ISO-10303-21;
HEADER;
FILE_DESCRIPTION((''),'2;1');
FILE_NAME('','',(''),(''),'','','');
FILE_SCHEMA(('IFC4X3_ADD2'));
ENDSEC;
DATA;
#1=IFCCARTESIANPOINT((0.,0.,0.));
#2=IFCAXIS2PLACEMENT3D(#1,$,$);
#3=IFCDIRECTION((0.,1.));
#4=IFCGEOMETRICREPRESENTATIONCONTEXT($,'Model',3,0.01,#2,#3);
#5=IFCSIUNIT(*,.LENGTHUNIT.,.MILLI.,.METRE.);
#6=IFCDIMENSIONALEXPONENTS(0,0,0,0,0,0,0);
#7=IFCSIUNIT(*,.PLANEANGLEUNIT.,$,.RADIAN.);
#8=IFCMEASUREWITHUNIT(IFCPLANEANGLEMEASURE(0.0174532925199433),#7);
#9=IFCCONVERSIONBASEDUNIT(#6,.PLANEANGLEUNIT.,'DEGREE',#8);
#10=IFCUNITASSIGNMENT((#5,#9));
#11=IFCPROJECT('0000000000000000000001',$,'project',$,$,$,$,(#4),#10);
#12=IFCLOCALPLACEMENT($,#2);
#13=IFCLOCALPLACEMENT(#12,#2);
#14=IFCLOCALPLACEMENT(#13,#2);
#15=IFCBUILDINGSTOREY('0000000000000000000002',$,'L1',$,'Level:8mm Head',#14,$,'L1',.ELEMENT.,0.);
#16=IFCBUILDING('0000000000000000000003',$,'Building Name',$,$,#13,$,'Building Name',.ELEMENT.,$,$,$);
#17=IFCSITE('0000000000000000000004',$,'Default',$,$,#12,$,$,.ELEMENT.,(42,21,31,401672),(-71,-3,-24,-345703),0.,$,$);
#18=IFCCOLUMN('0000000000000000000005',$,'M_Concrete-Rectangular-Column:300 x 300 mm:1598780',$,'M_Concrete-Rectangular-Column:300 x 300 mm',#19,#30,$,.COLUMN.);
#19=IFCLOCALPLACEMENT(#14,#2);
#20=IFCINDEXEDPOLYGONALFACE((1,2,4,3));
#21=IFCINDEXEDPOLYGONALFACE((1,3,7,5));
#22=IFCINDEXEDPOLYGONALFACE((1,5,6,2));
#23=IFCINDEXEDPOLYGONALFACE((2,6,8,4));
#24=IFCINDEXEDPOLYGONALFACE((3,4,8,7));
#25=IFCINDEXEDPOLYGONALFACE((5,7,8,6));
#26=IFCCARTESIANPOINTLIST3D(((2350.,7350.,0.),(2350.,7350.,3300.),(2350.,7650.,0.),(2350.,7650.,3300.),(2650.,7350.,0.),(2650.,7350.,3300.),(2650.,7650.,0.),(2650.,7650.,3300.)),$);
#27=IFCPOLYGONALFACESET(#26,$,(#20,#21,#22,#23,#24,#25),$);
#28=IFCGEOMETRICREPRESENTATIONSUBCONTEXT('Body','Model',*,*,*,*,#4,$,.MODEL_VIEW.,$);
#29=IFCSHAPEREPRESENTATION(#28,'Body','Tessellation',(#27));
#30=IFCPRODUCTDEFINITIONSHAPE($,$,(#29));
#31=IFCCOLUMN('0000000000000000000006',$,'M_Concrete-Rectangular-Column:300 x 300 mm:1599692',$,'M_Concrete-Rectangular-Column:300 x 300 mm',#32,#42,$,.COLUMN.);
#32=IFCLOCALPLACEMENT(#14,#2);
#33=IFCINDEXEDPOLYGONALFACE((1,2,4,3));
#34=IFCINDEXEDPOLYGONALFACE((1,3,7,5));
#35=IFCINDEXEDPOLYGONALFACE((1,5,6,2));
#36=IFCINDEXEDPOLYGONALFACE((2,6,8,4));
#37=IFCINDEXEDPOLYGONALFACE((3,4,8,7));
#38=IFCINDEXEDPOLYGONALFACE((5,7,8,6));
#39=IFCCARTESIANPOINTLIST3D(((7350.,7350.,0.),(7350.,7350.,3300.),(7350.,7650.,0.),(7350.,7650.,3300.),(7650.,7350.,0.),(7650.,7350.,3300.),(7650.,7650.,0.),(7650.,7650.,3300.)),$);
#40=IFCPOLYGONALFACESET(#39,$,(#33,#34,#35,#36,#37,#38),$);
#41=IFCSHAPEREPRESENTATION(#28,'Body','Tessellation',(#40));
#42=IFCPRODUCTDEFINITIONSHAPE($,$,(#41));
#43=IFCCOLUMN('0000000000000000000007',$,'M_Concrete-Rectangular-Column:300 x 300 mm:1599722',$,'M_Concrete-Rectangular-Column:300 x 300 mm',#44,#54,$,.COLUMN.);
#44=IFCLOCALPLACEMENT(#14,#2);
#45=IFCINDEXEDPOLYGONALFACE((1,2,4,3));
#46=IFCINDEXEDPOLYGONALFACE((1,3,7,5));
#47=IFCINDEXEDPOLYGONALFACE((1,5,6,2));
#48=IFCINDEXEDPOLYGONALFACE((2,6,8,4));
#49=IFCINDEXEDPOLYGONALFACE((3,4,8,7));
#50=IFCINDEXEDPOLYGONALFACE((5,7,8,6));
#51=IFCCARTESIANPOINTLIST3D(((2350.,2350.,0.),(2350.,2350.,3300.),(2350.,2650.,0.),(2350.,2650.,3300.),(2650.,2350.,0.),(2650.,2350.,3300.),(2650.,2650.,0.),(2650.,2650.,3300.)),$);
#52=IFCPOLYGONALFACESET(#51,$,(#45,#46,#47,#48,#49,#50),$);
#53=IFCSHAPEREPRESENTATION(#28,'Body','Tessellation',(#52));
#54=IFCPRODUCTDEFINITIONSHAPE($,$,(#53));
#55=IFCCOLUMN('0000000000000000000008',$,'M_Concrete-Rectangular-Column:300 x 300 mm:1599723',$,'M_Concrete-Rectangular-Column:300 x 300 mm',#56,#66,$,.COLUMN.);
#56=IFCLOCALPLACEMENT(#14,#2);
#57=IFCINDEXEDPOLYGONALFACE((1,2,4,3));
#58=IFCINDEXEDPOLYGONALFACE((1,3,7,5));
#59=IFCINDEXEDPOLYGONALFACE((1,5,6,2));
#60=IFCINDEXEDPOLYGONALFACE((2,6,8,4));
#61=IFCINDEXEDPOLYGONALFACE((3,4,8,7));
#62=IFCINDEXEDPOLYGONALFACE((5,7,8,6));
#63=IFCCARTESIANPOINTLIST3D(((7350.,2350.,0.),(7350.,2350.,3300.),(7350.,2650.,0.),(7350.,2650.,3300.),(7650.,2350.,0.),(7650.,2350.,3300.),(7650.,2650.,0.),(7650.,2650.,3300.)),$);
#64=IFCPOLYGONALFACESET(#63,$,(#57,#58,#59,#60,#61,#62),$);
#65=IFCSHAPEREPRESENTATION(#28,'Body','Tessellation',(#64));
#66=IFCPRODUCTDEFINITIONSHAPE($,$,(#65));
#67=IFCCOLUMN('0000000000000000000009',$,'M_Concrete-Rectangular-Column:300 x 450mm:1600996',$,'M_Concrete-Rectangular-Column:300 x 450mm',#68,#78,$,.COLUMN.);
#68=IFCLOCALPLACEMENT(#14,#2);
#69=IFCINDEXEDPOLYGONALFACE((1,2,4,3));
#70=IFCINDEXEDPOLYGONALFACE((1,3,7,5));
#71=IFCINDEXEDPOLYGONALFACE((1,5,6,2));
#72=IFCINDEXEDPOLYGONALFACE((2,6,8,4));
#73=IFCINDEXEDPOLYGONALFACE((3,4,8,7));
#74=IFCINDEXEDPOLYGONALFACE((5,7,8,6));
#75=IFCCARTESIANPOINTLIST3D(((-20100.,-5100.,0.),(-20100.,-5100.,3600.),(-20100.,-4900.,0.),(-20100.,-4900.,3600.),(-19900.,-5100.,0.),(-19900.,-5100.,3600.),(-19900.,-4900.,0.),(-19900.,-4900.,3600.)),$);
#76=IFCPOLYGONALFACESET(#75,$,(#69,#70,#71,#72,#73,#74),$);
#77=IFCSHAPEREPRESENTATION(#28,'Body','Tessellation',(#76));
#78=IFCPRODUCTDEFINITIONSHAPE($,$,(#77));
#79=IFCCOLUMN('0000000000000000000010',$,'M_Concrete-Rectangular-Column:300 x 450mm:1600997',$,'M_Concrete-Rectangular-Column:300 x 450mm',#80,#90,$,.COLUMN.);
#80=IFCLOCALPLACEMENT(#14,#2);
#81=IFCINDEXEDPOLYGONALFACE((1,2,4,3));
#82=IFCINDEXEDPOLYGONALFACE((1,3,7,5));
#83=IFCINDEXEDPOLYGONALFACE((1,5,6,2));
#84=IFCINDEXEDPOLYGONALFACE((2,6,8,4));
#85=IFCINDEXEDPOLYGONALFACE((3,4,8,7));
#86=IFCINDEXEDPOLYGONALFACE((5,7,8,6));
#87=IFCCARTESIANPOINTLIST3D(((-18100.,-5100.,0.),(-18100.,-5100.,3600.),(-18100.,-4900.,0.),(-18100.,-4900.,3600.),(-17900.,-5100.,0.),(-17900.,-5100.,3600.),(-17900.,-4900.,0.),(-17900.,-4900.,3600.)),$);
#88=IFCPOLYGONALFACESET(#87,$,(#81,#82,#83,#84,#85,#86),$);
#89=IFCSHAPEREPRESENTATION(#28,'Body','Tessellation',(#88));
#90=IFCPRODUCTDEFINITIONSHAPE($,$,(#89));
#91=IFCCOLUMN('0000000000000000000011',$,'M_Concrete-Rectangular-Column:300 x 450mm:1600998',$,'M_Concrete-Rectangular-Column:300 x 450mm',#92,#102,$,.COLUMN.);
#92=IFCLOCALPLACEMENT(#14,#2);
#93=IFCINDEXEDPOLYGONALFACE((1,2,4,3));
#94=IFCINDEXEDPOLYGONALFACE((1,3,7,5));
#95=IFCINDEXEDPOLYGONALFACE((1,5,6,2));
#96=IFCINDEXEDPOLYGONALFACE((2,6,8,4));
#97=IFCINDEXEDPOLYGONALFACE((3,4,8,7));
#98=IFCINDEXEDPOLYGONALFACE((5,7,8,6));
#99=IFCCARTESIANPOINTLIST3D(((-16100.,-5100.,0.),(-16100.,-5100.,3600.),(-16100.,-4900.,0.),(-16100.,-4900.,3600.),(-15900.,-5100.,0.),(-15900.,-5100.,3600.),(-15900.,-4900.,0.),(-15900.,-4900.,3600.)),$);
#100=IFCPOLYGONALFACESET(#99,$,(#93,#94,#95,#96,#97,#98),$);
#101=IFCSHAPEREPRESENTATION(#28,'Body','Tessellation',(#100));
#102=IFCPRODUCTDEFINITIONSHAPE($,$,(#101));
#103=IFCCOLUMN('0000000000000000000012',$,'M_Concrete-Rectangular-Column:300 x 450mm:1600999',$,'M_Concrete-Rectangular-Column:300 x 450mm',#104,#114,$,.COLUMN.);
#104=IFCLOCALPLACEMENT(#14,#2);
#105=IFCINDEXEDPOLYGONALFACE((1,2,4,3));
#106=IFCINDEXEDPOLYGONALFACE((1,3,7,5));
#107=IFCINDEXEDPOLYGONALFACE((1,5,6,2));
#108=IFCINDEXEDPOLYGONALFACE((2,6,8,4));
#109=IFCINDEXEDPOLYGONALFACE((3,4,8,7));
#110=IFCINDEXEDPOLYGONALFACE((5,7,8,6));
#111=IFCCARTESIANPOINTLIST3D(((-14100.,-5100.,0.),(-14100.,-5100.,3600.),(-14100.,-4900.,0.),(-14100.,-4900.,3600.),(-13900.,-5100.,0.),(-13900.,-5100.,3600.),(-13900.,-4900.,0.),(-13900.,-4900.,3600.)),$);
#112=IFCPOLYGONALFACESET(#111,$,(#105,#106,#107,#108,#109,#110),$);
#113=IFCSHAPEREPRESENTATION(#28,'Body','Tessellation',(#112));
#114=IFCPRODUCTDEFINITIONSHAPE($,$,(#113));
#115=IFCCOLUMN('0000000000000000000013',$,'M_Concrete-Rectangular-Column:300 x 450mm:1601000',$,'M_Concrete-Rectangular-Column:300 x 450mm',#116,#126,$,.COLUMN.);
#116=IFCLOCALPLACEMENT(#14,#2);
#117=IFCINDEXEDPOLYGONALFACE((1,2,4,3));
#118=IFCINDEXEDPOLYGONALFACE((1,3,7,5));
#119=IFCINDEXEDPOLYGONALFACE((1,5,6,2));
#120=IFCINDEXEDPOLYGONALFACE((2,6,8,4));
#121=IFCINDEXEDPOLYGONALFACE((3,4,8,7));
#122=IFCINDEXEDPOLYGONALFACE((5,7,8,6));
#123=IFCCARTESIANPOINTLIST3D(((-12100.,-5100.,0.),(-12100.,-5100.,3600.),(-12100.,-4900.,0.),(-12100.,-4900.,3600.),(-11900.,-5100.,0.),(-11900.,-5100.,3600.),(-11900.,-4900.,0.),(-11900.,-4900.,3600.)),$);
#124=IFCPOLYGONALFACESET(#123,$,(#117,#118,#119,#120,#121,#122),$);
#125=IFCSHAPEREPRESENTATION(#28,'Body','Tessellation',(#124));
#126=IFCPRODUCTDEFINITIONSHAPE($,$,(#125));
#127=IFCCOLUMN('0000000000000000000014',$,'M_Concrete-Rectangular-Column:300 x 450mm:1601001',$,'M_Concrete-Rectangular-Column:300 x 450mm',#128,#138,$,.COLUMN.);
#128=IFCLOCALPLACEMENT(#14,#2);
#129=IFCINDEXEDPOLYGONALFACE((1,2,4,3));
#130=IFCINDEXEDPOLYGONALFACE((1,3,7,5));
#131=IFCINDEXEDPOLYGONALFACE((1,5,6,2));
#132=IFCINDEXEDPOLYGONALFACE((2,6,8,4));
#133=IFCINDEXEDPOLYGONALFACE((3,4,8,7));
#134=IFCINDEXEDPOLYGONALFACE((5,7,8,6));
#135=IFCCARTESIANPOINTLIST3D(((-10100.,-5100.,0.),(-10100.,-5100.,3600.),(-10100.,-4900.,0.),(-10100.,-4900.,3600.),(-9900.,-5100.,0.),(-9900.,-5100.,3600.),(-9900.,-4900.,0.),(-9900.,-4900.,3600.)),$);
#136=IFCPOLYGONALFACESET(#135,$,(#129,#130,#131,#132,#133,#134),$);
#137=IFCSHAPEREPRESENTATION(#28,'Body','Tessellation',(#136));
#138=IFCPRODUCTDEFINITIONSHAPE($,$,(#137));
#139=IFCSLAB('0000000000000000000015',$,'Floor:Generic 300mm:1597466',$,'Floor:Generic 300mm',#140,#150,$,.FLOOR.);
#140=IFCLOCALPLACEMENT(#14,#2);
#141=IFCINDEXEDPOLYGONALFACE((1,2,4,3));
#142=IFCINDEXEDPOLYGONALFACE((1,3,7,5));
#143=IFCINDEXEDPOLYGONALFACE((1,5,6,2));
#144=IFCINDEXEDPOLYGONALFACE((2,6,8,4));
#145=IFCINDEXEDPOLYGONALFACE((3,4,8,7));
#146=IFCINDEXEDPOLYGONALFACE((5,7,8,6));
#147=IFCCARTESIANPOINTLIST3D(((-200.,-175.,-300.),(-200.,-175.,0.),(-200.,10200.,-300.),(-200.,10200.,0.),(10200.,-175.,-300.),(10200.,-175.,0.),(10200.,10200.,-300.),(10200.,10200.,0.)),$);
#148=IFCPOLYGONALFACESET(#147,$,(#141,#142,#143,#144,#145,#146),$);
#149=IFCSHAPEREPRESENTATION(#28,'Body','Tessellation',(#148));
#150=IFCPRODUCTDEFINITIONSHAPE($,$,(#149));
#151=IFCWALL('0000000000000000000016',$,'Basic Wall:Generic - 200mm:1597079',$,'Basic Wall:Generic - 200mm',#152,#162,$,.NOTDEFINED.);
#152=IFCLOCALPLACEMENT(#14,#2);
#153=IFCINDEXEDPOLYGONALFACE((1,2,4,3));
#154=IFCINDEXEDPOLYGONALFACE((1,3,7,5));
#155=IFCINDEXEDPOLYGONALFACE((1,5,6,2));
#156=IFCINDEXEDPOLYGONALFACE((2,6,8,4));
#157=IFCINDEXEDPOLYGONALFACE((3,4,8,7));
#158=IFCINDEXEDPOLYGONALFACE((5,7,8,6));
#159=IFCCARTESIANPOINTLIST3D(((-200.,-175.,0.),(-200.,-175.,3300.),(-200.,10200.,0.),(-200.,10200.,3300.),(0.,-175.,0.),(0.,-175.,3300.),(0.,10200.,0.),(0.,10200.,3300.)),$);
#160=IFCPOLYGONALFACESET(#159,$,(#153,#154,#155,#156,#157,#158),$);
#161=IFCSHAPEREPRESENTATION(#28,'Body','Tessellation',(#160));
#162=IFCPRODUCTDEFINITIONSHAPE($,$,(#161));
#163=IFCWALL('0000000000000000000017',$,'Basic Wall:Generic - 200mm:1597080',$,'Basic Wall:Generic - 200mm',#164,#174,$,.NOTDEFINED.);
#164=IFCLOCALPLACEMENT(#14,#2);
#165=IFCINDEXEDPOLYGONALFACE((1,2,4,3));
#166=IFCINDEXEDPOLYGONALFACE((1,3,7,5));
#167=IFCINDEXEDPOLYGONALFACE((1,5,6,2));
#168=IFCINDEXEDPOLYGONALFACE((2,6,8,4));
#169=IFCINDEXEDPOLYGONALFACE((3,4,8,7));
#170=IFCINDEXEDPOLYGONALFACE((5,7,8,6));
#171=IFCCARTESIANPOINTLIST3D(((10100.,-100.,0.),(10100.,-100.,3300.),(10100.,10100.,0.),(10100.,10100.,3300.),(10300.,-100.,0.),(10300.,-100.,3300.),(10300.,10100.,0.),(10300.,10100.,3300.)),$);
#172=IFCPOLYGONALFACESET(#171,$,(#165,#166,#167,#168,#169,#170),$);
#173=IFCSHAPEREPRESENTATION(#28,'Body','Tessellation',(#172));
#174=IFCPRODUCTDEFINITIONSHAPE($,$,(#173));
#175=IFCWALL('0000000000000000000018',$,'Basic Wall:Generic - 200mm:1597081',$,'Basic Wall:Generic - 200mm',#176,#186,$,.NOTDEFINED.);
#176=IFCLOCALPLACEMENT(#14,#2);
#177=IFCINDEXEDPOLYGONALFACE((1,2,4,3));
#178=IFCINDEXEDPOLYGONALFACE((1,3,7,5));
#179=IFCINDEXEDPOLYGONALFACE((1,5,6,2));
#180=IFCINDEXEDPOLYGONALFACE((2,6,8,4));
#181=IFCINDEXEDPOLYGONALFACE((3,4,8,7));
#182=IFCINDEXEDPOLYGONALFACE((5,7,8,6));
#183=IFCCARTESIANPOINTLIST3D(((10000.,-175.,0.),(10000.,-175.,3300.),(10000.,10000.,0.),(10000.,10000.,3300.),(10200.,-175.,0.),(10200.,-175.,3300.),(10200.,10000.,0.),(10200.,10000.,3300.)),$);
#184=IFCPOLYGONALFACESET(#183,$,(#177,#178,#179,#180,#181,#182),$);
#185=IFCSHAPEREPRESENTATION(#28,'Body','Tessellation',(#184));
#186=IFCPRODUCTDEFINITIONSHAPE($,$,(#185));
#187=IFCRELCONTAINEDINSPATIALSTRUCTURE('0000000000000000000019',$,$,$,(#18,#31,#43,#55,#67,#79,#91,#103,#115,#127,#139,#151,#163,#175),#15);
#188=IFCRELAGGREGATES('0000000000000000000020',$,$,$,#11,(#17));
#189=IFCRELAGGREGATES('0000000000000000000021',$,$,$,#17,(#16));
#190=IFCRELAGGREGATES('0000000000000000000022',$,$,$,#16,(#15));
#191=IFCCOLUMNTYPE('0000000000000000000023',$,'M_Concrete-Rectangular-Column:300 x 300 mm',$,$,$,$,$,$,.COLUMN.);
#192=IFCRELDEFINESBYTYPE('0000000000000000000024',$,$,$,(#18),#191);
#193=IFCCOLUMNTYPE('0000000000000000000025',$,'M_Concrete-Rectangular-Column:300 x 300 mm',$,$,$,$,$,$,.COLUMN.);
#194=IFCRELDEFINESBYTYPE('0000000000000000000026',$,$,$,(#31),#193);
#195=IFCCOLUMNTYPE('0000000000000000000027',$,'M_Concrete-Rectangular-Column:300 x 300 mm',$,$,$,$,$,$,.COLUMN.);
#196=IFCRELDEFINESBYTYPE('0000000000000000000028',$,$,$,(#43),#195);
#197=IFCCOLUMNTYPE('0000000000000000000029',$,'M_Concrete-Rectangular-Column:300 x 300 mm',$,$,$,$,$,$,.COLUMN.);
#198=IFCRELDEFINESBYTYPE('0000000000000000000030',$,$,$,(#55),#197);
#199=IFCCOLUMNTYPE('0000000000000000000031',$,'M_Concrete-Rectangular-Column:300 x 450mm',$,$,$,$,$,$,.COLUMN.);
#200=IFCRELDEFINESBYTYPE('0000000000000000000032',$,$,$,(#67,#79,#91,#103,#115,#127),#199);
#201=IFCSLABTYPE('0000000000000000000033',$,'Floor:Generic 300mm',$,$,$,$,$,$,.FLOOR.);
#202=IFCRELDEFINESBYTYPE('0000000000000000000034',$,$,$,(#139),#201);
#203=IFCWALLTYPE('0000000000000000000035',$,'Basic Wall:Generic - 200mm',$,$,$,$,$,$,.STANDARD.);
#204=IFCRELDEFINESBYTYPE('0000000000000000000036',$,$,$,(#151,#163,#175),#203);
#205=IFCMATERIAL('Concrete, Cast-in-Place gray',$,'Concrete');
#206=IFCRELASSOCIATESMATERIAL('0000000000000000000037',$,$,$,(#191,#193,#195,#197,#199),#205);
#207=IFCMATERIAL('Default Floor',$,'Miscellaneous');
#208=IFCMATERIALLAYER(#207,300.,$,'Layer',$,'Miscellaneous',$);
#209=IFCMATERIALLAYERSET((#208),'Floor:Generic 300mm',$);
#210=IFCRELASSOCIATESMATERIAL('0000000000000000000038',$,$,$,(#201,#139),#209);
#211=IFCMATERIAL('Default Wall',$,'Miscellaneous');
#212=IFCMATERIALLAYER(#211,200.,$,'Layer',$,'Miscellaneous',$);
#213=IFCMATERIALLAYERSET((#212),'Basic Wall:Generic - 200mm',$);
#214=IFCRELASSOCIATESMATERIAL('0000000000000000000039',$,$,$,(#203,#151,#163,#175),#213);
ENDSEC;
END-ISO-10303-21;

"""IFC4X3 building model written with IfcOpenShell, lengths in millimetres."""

from ifc_helpers import new_model, entity, si_unit, converted_unit, direction, frame, frame_2d, origin, origin_2d_with_axis, place, context, subcontext, project, spatial, rectangle, extrude, source, transform, mapped, material, layer, layer_set, layer_usage, material_profile, profile_set, type_object, type_shapes, element, save


model = new_model("IFC4X3")

# Units and contexts
model_context = context("Model", 3, precision=0.01, world=origin(), true_north=direction((0.0, 1.0)))
body_context = subcontext(model_context, "Body", "Model", "MODEL_VIEW")
ifc_project = project(units=[si_unit("LENGTHUNIT", "METRE", prefix="MILLI"), converted_unit("PLANEANGLEUNIT", "DEGREE", entity("IfcPlaneAngleMeasure", 0.0174532925199433), si_unit("PLANEANGLEUNIT", "RADIAN"), dimensions=[0, 0, 0, 0, 0, 0, 0])], contexts=[model_context])

# Site, building, storey
site_placement = place(None, origin())
site = spatial("IfcSite", under=ifc_project, at=site_placement, Name="Default", CompositionType="ELEMENT", RefLatitude=(42, 21, 31, 401672), RefLongitude=(-71, -3, -24, -345703), RefElevation=0.0)
building_placement = place(site_placement, origin())
building = spatial("IfcBuilding", under=site, at=building_placement, Name="Building Name", LongName="Building Name", CompositionType="ELEMENT")
storey_placement = place(building_placement, origin())
storey = spatial("IfcBuildingStorey", under=building, at=storey_placement, Name="L1", ObjectType="Level:8mm Head", LongName="L1", CompositionType="ELEMENT", Elevation=0.0)

# Columns
ifc_material_1 = material(Name="Concrete, Cast-in-Place gray", Category="Concrete")
ifc_material_profile_1 = material_profile(ifc_material_1, rectangle(XDim=300.0, YDim=300.0, at=origin_2d_with_axis()), Name="300 x 300 mm")
ifc_profile_set_1 = profile_set([ifc_material_profile_1], Name="300 x 300 mm")
column_type_1 = type_object("IfcColumnType", Name="M_Concrete-Rectangular-Column:300 x 300 mm", PredefinedType="COLUMN", material=ifc_profile_set_1)
shared_shape_1 = source(origin(), body_context, "Body", "SweptSolid", [
    extrude(rectangle(XDim=300.0, YDim=300.0, at=origin_2d_with_axis()), frame((2500.0, 7500.0, 0.0)), (0.0, 0.0, 1.0), 3300.0),
])
type_shapes(column_type_1, [shared_shape_1])
column_1_placement = place(storey_placement, origin())
element("IfcColumn", 1, at=column_1_placement, inside=storey, type_object=column_type_1, Name="M_Concrete-Rectangular-Column:300 x 300 mm:1598780", ObjectType="M_Concrete-Rectangular-Column:300 x 300 mm", PredefinedType="COLUMN", context=body_context, shape_type="MappedRepresentation", body=[
    mapped(shared_shape_1, transform((0.0, 0.0, 0.0), scale=1.0)),
])
column_type_2 = type_object("IfcColumnType", Name="M_Concrete-Rectangular-Column:300 x 300 mm", PredefinedType="COLUMN", material=ifc_profile_set_1)
shared_shape_2 = source(origin(), body_context, "Body", "SweptSolid", [
    extrude(rectangle(XDim=300.0, YDim=300.0, at=origin_2d_with_axis()), frame((7500.0, 7500.0, 0.0)), (0.0, 0.0, 1.0), 3300.0),
])
type_shapes(column_type_2, [shared_shape_2])
column_2_placement = place(storey_placement, origin())
element("IfcColumn", 2, at=column_2_placement, inside=storey, type_object=column_type_2, Name="M_Concrete-Rectangular-Column:300 x 300 mm:1599692", ObjectType="M_Concrete-Rectangular-Column:300 x 300 mm", PredefinedType="COLUMN", context=body_context, shape_type="MappedRepresentation", body=[
    mapped(shared_shape_2, transform((0.0, 0.0, 0.0), scale=1.0)),
])
column_type_3 = type_object("IfcColumnType", Name="M_Concrete-Rectangular-Column:300 x 300 mm", PredefinedType="COLUMN", material=ifc_profile_set_1)
shared_shape_3 = source(origin(), body_context, "Body", "SweptSolid", [
    extrude(rectangle(XDim=300.0, YDim=300.0, at=origin_2d_with_axis()), frame((2500.0, 2500.0, 0.0)), (0.0, 0.0, 1.0), 3300.0),
])
type_shapes(column_type_3, [shared_shape_3])
column_3_placement = place(storey_placement, origin())
element("IfcColumn", 3, at=column_3_placement, inside=storey, type_object=column_type_3, Name="M_Concrete-Rectangular-Column:300 x 300 mm:1599722", ObjectType="M_Concrete-Rectangular-Column:300 x 300 mm", PredefinedType="COLUMN", context=body_context, shape_type="MappedRepresentation", body=[
    mapped(shared_shape_3, transform((0.0, 0.0, 0.0), scale=1.0)),
])
column_type_4 = type_object("IfcColumnType", Name="M_Concrete-Rectangular-Column:300 x 300 mm", PredefinedType="COLUMN", material=ifc_profile_set_1)
shared_shape_4 = source(origin(), body_context, "Body", "SweptSolid", [
    extrude(rectangle(XDim=300.0, YDim=300.0, at=origin_2d_with_axis()), frame((7500.0, 2500.0, 0.0)), (0.0, 0.0, 1.0), 3300.0),
])
type_shapes(column_type_4, [shared_shape_4])
column_4_placement = place(storey_placement, origin())
element("IfcColumn", 4, at=column_4_placement, inside=storey, type_object=column_type_4, Name="M_Concrete-Rectangular-Column:300 x 300 mm:1599723", ObjectType="M_Concrete-Rectangular-Column:300 x 300 mm", PredefinedType="COLUMN", context=body_context, shape_type="MappedRepresentation", body=[
    mapped(shared_shape_4, transform((0.0, 0.0, 0.0), scale=1.0)),
])
ifc_material_profile_2 = material_profile(ifc_material_1, rectangle(XDim=200.0, YDim=200.0, at=origin_2d_with_axis()), Name="300 x 450mm")
ifc_profile_set_2 = profile_set([ifc_material_profile_2], Name="300 x 450mm")
column_type_5 = type_object("IfcColumnType", Name="M_Concrete-Rectangular-Column:300 x 450mm", PredefinedType="COLUMN", material=ifc_profile_set_2)
shared_shape_5 = source(origin(), body_context, "Body", "SweptSolid", [
    extrude(rectangle(XDim=200.0, YDim=200.0, at=origin_2d_with_axis()), frame((0.0, 0.0, 0.0), z_axis=(0.0, 0.0, 1.0), x_axis=(0.0, -1.0, 0.0)), (0.0, 0.0, 1.0), 3600.0),
])
type_shapes(column_type_5, [shared_shape_5])
for number, where, z_axis, x_axis, name in (
    (5, (-20000.0, -5000.0, 0.0), (0.0, 0.0, 1.0), (0.0, -1.0, 0.0), "M_Concrete-Rectangular-Column:300 x 450mm:1600996"),
    (6, (-18000.0, -5000.0, 0.0), (0.0, 0.0, 1.0), (0.0, -1.0, 0.0), "M_Concrete-Rectangular-Column:300 x 450mm:1600997"),
    (7, (-16000.0, -5000.0, 0.0), (0.0, 0.0, 1.0), (0.0, -1.0, 0.0), "M_Concrete-Rectangular-Column:300 x 450mm:1600998"),
    (8, (-14000.0, -5000.0, 0.0), (0.0, 0.0, 1.0), (0.0, -1.0, 0.0), "M_Concrete-Rectangular-Column:300 x 450mm:1600999"),
    (9, (-12000.0, -5000.0, 0.0), (0.0, 0.0, 1.0), (0.0, -1.0, 0.0), "M_Concrete-Rectangular-Column:300 x 450mm:1601000"),
    (10, (-10000.0, -5000.0, 0.0), (0.0, 0.0, 1.0), (0.0, -1.0, 0.0), "M_Concrete-Rectangular-Column:300 x 450mm:1601001"),
):
    element("IfcColumn", number, at=place(storey_placement, frame(where, z_axis=z_axis, x_axis=x_axis)), inside=storey, type_object=column_type_5, Name=name, ObjectType="M_Concrete-Rectangular-Column:300 x 450mm", PredefinedType="COLUMN", context=body_context, shape_type="MappedRepresentation", body=[
        mapped(shared_shape_5, transform((0.0, 0.0, 0.0), scale=1.0)),
    ])

# Slab
ifc_material_2 = material(Name="Default Floor", Category="Miscellaneous")
ifc_layer_1 = layer(ifc_material_2, 300.0, Name="Layer", Category="Miscellaneous")
ifc_layer_set_1 = layer_set([ifc_layer_1], Name="Floor:Generic 300mm")
ifc_layer_usage = layer_usage(ifc_layer_set_1, "AXIS3", "POSITIVE", 0.0)
slab_type = type_object("IfcSlabType", Name="Floor:Generic 300mm", PredefinedType="FLOOR", material=ifc_layer_set_1)
slab_placement = place(storey_placement, origin())
element("IfcSlab", 11, at=slab_placement, inside=storey, type_object=slab_type, material=ifc_layer_usage, Name="Floor:Generic 300mm:1597466", ObjectType="Floor:Generic 300mm", PredefinedType="FLOOR", context=body_context, shape_type="SweptSolid", body=[
    extrude(rectangle(XDim=10375.0, YDim=10400.0, at=origin_2d_with_axis()), frame((5000.0, 5012.5, 0.0), z_axis=(0.0, 0.0, -1.0), x_axis=(0.0, 1.0, 0.0)), (0.0, 0.0, 1.0), 300.0),
])

# Walls
ifc_material_3 = material(Name="Default Wall", Category="Miscellaneous")
ifc_layer_2 = layer(ifc_material_3, 200.0, Name="Layer", Category="Miscellaneous")
ifc_layer_set_2 = layer_set([ifc_layer_2], Name="Basic Wall:Generic - 200mm")
wall_type_1 = type_object("IfcWallType", Name="Basic Wall:Generic - 200mm", PredefinedType="STANDARD", material=ifc_layer_set_2)
wall_1_placement = place(storey_placement, frame((-100.0, 10200.0, 0.0), z_axis=(0.0, 0.0, 1.0), x_axis=(0.0, -1.0, 0.0)))
element("IfcWall", 12, at=wall_1_placement, inside=storey, type_object=wall_type_1, material=ifc_layer_set_2, Name="Basic Wall:Generic - 200mm:1597079", ObjectType="Basic Wall:Generic - 200mm", PredefinedType="NOTDEFINED", context=body_context, shape_type="SweptSolid", body=[
    extrude(rectangle(XDim=10375.0, YDim=200.0, at=frame_2d((5187.5, 0.0), x_axis=(-1.0, 0.0))), origin(), (0.0, 0.0, 1.0), 3300.0),
])
wall_2_placement = place(storey_placement, frame((10200.0, 10100.0, 0.0), z_axis=(0.0, 0.0, 1.0), x_axis=(0.0, -1.0, 0.0)))
element("IfcWall", 13, at=wall_2_placement, inside=storey, type_object=wall_type_1, material=ifc_layer_set_2, Name="Basic Wall:Generic - 200mm:1597080", ObjectType="Basic Wall:Generic - 200mm", PredefinedType="NOTDEFINED", context=body_context, shape_type="SweptSolid", body=[
    extrude(rectangle(XDim=10200.0, YDim=200.0, at=frame_2d((5100.0, 0.0), x_axis=(-1.0, 0.0))), origin(), (0.0, 0.0, 1.0), 3300.0),
])
wall_3_placement = place(storey_placement, frame((10100.0, -175.0, 0.0), z_axis=(0.0, 0.0, 1.0), x_axis=(0.0, 1.0, 0.0)))
element("IfcWall", 14, at=wall_3_placement, inside=storey, type_object=wall_type_1, material=ifc_layer_set_2, Name="Basic Wall:Generic - 200mm:1597081", ObjectType="Basic Wall:Generic - 200mm", PredefinedType="NOTDEFINED", context=body_context, shape_type="SweptSolid", body=[
    extrude(rectangle(XDim=10175.0, YDim=200.0, at=frame_2d((5087.5, 0.0), x_axis=(-1.0, 0.0))), origin(), (0.0, 0.0, 1.0), 3300.0),
])

save(model, "model.ifc")
